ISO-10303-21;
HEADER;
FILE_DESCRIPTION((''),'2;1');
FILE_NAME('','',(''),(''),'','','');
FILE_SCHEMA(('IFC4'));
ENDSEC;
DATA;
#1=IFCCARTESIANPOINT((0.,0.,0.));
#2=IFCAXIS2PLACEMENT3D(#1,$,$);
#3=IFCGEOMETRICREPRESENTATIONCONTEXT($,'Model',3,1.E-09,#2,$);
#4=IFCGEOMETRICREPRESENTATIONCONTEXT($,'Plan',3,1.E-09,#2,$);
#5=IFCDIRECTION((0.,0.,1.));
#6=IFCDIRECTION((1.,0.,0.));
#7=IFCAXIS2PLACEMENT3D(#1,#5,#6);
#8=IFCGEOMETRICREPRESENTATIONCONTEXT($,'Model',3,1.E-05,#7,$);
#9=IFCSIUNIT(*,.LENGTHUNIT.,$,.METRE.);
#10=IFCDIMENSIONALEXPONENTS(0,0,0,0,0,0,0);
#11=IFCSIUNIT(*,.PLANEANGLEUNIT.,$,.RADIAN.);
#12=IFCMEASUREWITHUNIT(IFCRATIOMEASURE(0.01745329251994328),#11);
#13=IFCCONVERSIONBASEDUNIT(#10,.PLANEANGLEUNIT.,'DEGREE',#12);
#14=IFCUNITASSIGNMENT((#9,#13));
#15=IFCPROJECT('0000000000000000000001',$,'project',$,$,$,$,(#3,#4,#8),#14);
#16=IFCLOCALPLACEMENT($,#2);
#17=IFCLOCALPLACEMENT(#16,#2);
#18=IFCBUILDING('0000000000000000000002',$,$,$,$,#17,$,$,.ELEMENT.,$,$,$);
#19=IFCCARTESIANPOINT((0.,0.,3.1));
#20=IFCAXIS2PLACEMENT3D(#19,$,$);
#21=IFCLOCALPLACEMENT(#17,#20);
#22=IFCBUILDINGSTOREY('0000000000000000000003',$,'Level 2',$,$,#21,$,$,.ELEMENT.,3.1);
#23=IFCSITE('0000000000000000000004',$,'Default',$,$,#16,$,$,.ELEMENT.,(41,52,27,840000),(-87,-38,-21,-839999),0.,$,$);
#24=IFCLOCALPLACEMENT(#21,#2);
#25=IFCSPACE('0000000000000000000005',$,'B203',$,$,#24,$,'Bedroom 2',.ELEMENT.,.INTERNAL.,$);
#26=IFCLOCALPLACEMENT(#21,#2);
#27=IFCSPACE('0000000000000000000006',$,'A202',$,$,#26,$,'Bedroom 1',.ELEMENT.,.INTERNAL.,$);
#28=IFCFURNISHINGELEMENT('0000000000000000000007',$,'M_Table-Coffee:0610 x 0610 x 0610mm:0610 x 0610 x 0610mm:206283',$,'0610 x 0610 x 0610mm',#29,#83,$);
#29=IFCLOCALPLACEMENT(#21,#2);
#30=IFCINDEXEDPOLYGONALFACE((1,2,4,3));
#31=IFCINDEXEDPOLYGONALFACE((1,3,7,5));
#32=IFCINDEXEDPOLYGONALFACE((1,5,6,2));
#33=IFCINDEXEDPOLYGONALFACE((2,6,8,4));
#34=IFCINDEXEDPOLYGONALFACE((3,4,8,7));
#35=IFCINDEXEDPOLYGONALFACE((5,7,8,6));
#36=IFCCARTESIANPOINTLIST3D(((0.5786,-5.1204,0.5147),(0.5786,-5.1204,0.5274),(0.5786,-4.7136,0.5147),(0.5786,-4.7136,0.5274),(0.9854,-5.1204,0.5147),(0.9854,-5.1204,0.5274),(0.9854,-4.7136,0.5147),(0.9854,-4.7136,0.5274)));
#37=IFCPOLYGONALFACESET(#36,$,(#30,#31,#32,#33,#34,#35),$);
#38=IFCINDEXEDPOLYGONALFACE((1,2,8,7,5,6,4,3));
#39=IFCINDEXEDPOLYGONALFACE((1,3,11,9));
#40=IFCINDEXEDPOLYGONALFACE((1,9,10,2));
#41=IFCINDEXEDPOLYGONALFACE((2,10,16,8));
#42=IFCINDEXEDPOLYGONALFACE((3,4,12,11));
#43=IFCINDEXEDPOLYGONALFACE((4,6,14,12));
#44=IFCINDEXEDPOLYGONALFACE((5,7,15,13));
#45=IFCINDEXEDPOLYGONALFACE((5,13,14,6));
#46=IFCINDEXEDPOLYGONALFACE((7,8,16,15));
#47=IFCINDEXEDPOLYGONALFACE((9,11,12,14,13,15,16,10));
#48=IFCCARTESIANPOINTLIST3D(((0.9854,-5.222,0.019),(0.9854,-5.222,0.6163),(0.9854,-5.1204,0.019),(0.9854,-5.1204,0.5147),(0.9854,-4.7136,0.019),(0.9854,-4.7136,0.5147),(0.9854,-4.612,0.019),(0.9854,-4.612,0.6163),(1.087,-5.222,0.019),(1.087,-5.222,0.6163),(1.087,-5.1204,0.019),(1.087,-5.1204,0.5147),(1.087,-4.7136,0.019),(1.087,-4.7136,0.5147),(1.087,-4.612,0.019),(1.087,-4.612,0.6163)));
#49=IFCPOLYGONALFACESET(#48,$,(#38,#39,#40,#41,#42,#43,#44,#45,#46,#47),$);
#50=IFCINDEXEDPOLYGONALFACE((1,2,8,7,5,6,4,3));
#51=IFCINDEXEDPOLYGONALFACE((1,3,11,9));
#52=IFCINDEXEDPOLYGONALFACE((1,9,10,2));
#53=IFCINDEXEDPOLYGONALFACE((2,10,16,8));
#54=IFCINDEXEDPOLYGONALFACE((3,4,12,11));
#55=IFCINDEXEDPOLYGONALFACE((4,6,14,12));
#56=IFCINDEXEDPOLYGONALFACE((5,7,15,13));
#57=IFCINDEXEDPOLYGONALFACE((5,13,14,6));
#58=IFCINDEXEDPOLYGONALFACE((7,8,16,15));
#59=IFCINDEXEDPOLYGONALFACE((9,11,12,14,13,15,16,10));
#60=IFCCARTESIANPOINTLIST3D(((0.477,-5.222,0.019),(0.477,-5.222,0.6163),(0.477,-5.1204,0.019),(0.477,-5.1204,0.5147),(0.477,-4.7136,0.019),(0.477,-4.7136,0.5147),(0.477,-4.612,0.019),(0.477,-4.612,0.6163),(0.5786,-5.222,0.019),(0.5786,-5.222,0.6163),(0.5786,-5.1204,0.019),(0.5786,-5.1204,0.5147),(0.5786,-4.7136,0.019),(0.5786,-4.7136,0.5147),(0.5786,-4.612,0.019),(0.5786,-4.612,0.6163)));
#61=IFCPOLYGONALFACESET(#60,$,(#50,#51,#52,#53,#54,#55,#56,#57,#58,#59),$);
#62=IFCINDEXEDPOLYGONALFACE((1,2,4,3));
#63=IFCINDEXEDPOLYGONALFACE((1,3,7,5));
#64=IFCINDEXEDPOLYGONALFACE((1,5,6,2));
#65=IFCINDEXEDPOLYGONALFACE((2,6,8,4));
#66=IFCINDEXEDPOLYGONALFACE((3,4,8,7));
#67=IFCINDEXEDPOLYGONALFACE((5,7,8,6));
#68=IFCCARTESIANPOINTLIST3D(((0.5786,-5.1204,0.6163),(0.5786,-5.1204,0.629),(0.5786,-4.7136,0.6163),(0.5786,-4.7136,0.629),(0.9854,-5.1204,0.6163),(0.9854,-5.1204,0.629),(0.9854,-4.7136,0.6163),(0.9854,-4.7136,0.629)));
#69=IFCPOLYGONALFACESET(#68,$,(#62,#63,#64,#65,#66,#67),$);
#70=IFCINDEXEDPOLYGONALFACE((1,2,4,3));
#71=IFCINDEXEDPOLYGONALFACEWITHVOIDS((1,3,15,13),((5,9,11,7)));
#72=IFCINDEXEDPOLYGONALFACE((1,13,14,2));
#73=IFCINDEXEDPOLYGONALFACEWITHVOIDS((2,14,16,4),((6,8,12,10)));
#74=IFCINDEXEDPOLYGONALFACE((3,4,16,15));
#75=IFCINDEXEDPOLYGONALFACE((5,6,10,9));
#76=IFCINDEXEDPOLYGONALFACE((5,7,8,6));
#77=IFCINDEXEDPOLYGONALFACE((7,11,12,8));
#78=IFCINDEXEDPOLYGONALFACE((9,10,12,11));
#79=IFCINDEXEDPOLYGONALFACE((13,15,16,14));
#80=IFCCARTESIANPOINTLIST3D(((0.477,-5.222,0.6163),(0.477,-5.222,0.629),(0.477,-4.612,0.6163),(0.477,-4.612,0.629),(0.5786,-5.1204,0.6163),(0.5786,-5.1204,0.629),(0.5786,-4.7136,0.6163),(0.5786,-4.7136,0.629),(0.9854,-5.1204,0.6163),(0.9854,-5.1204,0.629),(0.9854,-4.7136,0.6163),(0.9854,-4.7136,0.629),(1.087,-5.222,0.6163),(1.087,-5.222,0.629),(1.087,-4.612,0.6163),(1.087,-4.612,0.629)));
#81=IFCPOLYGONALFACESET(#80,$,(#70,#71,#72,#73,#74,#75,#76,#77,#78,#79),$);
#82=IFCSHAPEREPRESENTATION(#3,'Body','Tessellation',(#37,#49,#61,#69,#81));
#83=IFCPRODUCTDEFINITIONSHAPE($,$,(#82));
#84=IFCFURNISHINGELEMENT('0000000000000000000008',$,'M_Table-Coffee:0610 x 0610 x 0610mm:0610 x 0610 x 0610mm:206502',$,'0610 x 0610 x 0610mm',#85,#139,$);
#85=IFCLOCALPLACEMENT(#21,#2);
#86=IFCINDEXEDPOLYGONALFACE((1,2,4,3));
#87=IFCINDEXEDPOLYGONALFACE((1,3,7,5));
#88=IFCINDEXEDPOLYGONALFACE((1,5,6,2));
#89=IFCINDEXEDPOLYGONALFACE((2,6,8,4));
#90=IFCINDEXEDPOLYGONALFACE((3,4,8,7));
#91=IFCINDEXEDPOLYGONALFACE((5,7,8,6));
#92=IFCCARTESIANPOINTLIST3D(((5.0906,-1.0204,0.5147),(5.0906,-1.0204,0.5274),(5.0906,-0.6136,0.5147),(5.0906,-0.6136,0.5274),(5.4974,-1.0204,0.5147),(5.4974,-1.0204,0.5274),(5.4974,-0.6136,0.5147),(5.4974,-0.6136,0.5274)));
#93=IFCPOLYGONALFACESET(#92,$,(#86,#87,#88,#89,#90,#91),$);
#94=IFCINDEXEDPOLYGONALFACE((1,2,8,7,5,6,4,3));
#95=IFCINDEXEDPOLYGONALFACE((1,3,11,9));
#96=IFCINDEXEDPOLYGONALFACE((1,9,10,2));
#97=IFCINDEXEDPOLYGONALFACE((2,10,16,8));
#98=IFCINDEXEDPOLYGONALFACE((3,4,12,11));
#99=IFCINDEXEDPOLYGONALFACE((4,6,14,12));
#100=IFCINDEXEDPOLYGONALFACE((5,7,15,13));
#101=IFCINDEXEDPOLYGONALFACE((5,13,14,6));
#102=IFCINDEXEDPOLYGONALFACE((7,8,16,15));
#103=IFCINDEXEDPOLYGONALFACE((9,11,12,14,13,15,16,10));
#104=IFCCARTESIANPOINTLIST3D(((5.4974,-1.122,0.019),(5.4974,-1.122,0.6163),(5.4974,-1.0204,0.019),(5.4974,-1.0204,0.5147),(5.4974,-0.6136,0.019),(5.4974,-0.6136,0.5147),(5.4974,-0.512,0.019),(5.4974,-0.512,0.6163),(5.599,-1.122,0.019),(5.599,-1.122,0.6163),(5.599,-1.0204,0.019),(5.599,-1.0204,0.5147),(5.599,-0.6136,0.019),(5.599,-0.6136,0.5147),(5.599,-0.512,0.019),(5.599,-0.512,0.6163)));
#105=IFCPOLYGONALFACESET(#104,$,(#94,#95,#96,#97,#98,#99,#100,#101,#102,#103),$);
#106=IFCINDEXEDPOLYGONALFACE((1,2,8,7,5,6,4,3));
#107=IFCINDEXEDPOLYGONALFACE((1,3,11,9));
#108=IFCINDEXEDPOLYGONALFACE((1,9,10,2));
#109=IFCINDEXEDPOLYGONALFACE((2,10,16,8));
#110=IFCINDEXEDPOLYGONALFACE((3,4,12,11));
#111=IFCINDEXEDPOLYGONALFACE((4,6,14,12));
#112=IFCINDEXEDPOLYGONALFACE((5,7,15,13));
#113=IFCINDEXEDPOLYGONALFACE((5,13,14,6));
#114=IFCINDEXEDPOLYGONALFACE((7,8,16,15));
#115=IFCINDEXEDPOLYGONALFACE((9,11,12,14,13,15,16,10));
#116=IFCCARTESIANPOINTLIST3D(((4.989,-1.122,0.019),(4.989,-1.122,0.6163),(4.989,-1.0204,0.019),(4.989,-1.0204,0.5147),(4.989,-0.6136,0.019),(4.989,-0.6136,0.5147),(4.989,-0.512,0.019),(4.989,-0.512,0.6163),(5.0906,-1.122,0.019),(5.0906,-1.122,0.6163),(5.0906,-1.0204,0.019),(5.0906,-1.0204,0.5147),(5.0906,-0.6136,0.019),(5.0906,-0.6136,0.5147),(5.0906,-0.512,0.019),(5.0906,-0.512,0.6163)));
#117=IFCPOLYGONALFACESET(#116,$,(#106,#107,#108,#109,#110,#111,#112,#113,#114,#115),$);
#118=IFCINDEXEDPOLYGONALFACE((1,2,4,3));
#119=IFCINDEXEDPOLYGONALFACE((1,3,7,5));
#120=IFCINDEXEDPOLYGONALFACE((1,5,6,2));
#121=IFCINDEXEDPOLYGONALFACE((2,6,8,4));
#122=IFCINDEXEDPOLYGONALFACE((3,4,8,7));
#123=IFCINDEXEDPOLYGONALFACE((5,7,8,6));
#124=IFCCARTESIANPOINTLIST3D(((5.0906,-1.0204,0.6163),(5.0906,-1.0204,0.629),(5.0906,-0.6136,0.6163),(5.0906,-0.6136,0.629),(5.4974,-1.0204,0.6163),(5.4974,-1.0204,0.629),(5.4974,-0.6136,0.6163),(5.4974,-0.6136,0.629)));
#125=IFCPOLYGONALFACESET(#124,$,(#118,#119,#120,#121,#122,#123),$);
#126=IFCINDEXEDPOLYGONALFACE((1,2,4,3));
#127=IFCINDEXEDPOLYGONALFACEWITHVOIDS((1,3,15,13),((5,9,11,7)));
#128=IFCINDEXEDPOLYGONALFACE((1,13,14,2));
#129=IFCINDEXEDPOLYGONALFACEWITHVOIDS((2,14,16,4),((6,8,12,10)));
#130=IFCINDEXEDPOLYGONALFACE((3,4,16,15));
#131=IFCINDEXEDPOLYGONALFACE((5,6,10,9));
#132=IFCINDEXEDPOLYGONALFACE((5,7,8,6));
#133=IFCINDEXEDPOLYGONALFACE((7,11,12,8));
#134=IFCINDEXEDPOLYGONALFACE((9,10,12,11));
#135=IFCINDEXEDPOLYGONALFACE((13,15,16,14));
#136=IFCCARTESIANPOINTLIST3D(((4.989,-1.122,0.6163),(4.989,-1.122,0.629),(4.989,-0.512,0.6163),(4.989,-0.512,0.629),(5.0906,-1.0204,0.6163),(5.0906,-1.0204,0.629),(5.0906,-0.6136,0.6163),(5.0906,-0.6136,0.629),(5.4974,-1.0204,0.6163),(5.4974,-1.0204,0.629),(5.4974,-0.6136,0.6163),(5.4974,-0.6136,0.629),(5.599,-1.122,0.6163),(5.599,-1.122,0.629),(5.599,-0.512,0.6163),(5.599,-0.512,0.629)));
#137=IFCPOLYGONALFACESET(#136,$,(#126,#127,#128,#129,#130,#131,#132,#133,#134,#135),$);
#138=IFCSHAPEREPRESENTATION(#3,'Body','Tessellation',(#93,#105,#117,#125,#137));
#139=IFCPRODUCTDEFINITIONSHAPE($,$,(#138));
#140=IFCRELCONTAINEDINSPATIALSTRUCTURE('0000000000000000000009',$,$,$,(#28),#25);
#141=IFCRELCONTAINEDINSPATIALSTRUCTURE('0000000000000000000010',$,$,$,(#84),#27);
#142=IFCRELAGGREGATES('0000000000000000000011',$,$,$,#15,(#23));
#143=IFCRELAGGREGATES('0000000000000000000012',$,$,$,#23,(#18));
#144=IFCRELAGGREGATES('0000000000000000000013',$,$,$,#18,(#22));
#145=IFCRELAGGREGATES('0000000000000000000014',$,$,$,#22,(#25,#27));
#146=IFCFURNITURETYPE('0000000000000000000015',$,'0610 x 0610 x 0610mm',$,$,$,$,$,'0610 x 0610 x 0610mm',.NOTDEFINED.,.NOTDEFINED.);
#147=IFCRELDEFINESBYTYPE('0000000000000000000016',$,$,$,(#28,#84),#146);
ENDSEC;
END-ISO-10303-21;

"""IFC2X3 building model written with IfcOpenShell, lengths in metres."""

from ifc_helpers import new_model, entity, si_unit, converted_unit, frame, origin, origin_with_axes, origin_2d_with_axis, place, context, project, spatial, polyline, rectangle, outline, extrude, source, transform, mapped, type_object, type_shapes, element, save


model = new_model("IFC2X3")

# Units and contexts
model_context_1 = context("Model", 3, precision=1e-09, world=origin())
plan_context = context("Plan", 3, precision=1e-09, world=origin())
model_context_2 = context("Model", 3, precision=1e-05, world=origin_with_axes())
ifc_project = project(units=[si_unit("LENGTHUNIT", "METRE"), converted_unit("PLANEANGLEUNIT", "DEGREE", entity("IfcRatioMeasure", 0.01745329251994328), si_unit("PLANEANGLEUNIT", "RADIAN"), dimensions=[0, 0, 0, 0, 0, 0, 0])], contexts=[model_context_1, plan_context, model_context_2])

# Site, building, storey
site_placement = place(None, origin())
site = spatial("IfcSite", under=ifc_project, at=site_placement, Name="Default", CompositionType="ELEMENT", RefLatitude=(41, 52, 27, 840000), RefLongitude=(-87, -38, -21, -839999), RefElevation=0.0)
building_placement = place(site_placement, origin())
building = spatial("IfcBuilding", under=site, at=building_placement, CompositionType="ELEMENT")
storey_placement = place(building_placement, frame((0.0, 0.0, 3.1)))
storey = spatial("IfcBuildingStorey", under=building, at=storey_placement, Name="Level 2", CompositionType="ELEMENT", Elevation=3.1)

# Shared definitions
space_1_placement = place(storey_placement, origin())
space_1 = spatial("IfcSpace", under=storey, at=space_1_placement, Name="B203", LongName="Bedroom 2", CompositionType="ELEMENT", InteriorOrExteriorSpace="INTERNAL")

# Furnishing element
furniture_type = type_object("IfcFurnitureType", Name="0610 x 0610 x 0610mm", ElementType="0610 x 0610 x 0610mm", AssemblyPlace="NOTDEFINED")
shared_shape_1 = source(origin(), model_context_1, "Body", "SweptSolid", [
    extrude(rectangle(XDim=0.4068, YDim=0.4068, at=origin_2d_with_axis()), frame((0.0183, 0.0952, 0.4957), z_axis=(0.0, 0.0, 1.0), x_axis=(-1.0, 0.0, 0.0)), (0.0, 0.0, 1.0), 0.0127),
    extrude(outline(polyline([(-0.2732, -0.305), (0.324, -0.305), (0.324, 0.305), (-0.2732, 0.305), (-0.2732, 0.2034), (0.2225, 0.2034), (0.2225, -0.2034), (-0.2732, -0.2034), (-0.2732, -0.305)])), frame((0.2217, 0.0952, 0.2732), z_axis=(1.0, 0.0, 0.0), x_axis=(0.0, 0.0, 1.0)), (0.0, 0.0, 1.0), 0.1016),
    extrude(outline(polyline([(-0.305, -0.3241), (0.305, -0.3241), (0.305, 0.2733), (0.2034, 0.2733), (0.2034, -0.2224), (-0.2034, -0.2224), (-0.2034, 0.2733), (-0.305, 0.2733), (-0.305, -0.3241)])), frame((-0.2867, 0.0952, 0.2733), z_axis=(1.0, 0.0, 0.0), x_axis=(0.0, -1.0, 0.0)), (0.0, 0.0, 1.0), 0.1016),
    extrude(rectangle(XDim=0.4068, YDim=0.4068, at=origin_2d_with_axis()), frame((0.0183, 0.0952, 0.5973), z_axis=(0.0, 0.0, 1.0), x_axis=(-1.0, 0.0, 0.0)), (0.0, 0.0, 1.0), 0.0127),
    extrude(outline(polyline([(-0.305, -0.305), (0.305, -0.305), (0.305, 0.305), (-0.305, 0.305), (-0.305, -0.305)]), holes=[polyline([(-0.2034, -0.2034), (-0.2034, 0.2034), (0.2034, 0.2034), (0.2034, -0.2034), (-0.2034, -0.2034)])]), frame((0.0183, 0.0952, 0.5973), z_axis=(0.0, 0.0, 1.0), x_axis=(-1.0, 0.0, 0.0)), (0.0, 0.0, 1.0), 0.0127),
])
type_shapes(furniture_type, [shared_shape_1])
furnishing_1_placement = place(space_1_placement, frame((0.7637, -5.0122, 0.019)))
element("IfcFurnishingElement", 1, at=furnishing_1_placement, inside=space_1, type_object=furniture_type, Name="M_Table-Coffee:0610 x 0610 x 0610mm:0610 x 0610 x 0610mm:206283", ObjectType="0610 x 0610 x 0610mm", context=model_context_1, shape_type="MappedRepresentation", body=[
    mapped(shared_shape_1, transform((0.0, 0.0, 0.0), scale=1.0)),
])

# Shared definitions
space_2_placement = place(storey_placement, origin())
space_2 = spatial("IfcSpace", under=storey, at=space_2_placement, Name="A202", LongName="Bedroom 1", CompositionType="ELEMENT", InteriorOrExteriorSpace="INTERNAL")

# Furnishing element
furnishing_2_placement = place(space_2_placement, frame((5.2757, -0.9122, 0.019)))
element("IfcFurnishingElement", 2, at=furnishing_2_placement, inside=space_2, type_object=furniture_type, Name="M_Table-Coffee:0610 x 0610 x 0610mm:0610 x 0610 x 0610mm:206502", ObjectType="0610 x 0610 x 0610mm", context=model_context_1, shape_type="MappedRepresentation", body=[
    mapped(shared_shape_1, transform((0.0, 0.0, 0.0), scale=1.0)),
])

save(model, "model.ifc")
